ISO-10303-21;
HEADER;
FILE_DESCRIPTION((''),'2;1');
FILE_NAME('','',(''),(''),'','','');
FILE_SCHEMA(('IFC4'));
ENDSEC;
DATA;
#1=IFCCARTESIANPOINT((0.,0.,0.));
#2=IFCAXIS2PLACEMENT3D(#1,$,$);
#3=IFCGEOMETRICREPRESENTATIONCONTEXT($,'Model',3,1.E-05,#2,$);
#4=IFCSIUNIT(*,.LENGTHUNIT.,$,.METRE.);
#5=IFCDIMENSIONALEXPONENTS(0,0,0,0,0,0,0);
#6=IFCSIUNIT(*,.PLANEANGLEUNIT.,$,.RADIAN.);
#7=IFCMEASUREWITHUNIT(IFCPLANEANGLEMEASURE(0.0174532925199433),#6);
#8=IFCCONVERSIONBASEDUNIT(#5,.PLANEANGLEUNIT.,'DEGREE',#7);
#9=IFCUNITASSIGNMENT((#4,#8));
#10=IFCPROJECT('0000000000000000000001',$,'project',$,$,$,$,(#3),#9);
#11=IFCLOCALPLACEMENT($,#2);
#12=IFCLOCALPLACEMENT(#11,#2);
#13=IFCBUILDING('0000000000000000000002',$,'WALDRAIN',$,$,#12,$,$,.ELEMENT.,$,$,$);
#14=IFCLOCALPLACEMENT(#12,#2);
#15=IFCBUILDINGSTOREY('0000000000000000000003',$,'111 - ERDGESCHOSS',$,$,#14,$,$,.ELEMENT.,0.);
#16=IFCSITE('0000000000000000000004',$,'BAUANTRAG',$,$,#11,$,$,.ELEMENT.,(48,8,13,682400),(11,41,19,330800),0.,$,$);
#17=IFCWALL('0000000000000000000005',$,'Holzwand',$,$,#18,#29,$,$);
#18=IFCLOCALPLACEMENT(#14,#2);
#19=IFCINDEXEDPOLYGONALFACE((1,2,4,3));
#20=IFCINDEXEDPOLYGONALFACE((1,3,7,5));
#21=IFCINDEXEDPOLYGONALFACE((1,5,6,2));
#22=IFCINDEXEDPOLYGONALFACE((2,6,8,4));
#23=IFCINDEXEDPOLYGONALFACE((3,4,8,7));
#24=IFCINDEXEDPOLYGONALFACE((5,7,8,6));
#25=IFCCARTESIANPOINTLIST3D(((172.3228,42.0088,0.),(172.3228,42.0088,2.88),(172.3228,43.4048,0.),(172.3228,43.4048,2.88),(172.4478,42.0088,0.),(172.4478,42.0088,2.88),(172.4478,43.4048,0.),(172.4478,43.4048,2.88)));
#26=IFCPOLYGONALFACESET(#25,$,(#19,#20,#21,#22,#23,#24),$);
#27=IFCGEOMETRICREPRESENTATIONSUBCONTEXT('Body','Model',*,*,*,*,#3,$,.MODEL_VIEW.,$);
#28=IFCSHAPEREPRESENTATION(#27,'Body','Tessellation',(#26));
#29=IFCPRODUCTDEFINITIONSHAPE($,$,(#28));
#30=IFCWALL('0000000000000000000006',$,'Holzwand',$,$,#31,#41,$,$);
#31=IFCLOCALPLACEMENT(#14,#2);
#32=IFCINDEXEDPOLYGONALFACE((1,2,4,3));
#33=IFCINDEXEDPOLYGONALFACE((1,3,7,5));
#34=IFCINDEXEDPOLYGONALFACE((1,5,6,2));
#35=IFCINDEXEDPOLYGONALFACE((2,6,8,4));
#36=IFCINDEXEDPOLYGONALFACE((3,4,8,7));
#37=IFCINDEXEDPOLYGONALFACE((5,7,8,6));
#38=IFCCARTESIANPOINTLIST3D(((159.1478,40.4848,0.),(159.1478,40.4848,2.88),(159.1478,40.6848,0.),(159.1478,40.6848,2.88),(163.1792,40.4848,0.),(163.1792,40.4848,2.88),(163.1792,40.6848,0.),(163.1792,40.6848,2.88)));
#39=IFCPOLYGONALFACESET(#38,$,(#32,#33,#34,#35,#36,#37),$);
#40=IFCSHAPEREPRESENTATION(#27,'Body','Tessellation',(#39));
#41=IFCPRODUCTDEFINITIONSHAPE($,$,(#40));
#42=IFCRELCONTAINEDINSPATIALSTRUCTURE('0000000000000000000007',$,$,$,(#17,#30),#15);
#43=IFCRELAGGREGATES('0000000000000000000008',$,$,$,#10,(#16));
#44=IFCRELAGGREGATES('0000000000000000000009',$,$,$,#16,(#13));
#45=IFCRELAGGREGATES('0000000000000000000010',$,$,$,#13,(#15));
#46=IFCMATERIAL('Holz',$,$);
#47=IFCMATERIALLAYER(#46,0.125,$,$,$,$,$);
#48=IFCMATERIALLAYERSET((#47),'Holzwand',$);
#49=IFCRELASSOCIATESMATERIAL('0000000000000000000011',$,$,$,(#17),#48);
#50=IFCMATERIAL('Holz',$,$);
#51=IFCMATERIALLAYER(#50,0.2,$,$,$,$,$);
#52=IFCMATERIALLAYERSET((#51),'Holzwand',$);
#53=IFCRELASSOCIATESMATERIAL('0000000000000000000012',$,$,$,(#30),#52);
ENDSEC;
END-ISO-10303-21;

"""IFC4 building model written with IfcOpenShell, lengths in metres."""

from ifc_helpers import new_model, entity, si_unit, converted_unit, frame, frame_2d, origin, origin_with_axes, place, context, subcontext, project, spatial, rectangle, extrude, material, layer, layer_set, layer_usage, element, save


model = new_model("IFC4")

# Units and contexts
model_context = context("Model", 3, precision=1e-05, world=origin())
body_context = subcontext(model_context, "Body", "Model", "MODEL_VIEW")
ifc_project = project(units=[si_unit("LENGTHUNIT", "METRE"), converted_unit("PLANEANGLEUNIT", "DEGREE", entity("IfcPlaneAngleMeasure", 0.0174532925199433), si_unit("PLANEANGLEUNIT", "RADIAN"), dimensions=[0, 0, 0, 0, 0, 0, 0])], contexts=[model_context])

# Site, building, storey
site_placement = place(None, origin())
site = spatial("IfcSite", under=ifc_project, at=site_placement, Name="BAUANTRAG", CompositionType="ELEMENT", RefLatitude=(48, 8, 13, 682400), RefLongitude=(11, 41, 19, 330800), RefElevation=0.0)
building_placement = place(site_placement, origin())
building = spatial("IfcBuilding", under=site, at=building_placement, Name="WALDRAIN", CompositionType="ELEMENT")
storey_placement = place(building_placement, origin())
storey = spatial("IfcBuildingStorey", under=building, at=storey_placement, Name="111 - ERDGESCHOSS", CompositionType="ELEMENT", Elevation=0.0)

# Walls
ifc_material_1 = material(Name="Holz")
ifc_layer_1 = layer(ifc_material_1, 0.125)
ifc_layer_set_1 = layer_set([ifc_layer_1], Name="Holzwand")
ifc_layer_usage_1 = layer_usage(ifc_layer_set_1, "AXIS2", "POSITIVE", 0.0)
wall_1_placement = place(storey_placement, frame((172.4478, 42.0088, 0.0), z_axis=(0.0, 0.0, 1.0), x_axis=(0.0, 1.0, 0.0)))
element("IfcWall", 1, at=wall_1_placement, inside=storey, material=ifc_layer_usage_1, Name="Holzwand", context=body_context, shape_type="SweptSolid", body=[
    extrude(rectangle(XDim=1.396, YDim=0.125, at=frame_2d((0.698, 0.0625), x_axis=(1.0, 0.0))), origin_with_axes(), (0.0, 0.0, 1.0), 2.88),
])
ifc_material_2 = material(Name="Holz")
ifc_layer_2 = layer(ifc_material_2, 0.2)
ifc_layer_set_2 = layer_set([ifc_layer_2], Name="Holzwand")
ifc_layer_usage_2 = layer_usage(ifc_layer_set_2, "AXIS2", "POSITIVE", 0.0)
wall_2_placement = place(storey_placement, frame((159.1478, 40.4848, 0.0)))
element("IfcWall", 2, at=wall_2_placement, inside=storey, material=ifc_layer_usage_2, Name="Holzwand", context=body_context, shape_type="SweptSolid", body=[
    extrude(rectangle(XDim=4.0315, YDim=0.2, at=frame_2d((2.0157, 0.1), x_axis=(1.0, 0.0))), origin_with_axes(), (0.0, 0.0, 1.0), 2.88),
])

save(model, "model.ifc")
